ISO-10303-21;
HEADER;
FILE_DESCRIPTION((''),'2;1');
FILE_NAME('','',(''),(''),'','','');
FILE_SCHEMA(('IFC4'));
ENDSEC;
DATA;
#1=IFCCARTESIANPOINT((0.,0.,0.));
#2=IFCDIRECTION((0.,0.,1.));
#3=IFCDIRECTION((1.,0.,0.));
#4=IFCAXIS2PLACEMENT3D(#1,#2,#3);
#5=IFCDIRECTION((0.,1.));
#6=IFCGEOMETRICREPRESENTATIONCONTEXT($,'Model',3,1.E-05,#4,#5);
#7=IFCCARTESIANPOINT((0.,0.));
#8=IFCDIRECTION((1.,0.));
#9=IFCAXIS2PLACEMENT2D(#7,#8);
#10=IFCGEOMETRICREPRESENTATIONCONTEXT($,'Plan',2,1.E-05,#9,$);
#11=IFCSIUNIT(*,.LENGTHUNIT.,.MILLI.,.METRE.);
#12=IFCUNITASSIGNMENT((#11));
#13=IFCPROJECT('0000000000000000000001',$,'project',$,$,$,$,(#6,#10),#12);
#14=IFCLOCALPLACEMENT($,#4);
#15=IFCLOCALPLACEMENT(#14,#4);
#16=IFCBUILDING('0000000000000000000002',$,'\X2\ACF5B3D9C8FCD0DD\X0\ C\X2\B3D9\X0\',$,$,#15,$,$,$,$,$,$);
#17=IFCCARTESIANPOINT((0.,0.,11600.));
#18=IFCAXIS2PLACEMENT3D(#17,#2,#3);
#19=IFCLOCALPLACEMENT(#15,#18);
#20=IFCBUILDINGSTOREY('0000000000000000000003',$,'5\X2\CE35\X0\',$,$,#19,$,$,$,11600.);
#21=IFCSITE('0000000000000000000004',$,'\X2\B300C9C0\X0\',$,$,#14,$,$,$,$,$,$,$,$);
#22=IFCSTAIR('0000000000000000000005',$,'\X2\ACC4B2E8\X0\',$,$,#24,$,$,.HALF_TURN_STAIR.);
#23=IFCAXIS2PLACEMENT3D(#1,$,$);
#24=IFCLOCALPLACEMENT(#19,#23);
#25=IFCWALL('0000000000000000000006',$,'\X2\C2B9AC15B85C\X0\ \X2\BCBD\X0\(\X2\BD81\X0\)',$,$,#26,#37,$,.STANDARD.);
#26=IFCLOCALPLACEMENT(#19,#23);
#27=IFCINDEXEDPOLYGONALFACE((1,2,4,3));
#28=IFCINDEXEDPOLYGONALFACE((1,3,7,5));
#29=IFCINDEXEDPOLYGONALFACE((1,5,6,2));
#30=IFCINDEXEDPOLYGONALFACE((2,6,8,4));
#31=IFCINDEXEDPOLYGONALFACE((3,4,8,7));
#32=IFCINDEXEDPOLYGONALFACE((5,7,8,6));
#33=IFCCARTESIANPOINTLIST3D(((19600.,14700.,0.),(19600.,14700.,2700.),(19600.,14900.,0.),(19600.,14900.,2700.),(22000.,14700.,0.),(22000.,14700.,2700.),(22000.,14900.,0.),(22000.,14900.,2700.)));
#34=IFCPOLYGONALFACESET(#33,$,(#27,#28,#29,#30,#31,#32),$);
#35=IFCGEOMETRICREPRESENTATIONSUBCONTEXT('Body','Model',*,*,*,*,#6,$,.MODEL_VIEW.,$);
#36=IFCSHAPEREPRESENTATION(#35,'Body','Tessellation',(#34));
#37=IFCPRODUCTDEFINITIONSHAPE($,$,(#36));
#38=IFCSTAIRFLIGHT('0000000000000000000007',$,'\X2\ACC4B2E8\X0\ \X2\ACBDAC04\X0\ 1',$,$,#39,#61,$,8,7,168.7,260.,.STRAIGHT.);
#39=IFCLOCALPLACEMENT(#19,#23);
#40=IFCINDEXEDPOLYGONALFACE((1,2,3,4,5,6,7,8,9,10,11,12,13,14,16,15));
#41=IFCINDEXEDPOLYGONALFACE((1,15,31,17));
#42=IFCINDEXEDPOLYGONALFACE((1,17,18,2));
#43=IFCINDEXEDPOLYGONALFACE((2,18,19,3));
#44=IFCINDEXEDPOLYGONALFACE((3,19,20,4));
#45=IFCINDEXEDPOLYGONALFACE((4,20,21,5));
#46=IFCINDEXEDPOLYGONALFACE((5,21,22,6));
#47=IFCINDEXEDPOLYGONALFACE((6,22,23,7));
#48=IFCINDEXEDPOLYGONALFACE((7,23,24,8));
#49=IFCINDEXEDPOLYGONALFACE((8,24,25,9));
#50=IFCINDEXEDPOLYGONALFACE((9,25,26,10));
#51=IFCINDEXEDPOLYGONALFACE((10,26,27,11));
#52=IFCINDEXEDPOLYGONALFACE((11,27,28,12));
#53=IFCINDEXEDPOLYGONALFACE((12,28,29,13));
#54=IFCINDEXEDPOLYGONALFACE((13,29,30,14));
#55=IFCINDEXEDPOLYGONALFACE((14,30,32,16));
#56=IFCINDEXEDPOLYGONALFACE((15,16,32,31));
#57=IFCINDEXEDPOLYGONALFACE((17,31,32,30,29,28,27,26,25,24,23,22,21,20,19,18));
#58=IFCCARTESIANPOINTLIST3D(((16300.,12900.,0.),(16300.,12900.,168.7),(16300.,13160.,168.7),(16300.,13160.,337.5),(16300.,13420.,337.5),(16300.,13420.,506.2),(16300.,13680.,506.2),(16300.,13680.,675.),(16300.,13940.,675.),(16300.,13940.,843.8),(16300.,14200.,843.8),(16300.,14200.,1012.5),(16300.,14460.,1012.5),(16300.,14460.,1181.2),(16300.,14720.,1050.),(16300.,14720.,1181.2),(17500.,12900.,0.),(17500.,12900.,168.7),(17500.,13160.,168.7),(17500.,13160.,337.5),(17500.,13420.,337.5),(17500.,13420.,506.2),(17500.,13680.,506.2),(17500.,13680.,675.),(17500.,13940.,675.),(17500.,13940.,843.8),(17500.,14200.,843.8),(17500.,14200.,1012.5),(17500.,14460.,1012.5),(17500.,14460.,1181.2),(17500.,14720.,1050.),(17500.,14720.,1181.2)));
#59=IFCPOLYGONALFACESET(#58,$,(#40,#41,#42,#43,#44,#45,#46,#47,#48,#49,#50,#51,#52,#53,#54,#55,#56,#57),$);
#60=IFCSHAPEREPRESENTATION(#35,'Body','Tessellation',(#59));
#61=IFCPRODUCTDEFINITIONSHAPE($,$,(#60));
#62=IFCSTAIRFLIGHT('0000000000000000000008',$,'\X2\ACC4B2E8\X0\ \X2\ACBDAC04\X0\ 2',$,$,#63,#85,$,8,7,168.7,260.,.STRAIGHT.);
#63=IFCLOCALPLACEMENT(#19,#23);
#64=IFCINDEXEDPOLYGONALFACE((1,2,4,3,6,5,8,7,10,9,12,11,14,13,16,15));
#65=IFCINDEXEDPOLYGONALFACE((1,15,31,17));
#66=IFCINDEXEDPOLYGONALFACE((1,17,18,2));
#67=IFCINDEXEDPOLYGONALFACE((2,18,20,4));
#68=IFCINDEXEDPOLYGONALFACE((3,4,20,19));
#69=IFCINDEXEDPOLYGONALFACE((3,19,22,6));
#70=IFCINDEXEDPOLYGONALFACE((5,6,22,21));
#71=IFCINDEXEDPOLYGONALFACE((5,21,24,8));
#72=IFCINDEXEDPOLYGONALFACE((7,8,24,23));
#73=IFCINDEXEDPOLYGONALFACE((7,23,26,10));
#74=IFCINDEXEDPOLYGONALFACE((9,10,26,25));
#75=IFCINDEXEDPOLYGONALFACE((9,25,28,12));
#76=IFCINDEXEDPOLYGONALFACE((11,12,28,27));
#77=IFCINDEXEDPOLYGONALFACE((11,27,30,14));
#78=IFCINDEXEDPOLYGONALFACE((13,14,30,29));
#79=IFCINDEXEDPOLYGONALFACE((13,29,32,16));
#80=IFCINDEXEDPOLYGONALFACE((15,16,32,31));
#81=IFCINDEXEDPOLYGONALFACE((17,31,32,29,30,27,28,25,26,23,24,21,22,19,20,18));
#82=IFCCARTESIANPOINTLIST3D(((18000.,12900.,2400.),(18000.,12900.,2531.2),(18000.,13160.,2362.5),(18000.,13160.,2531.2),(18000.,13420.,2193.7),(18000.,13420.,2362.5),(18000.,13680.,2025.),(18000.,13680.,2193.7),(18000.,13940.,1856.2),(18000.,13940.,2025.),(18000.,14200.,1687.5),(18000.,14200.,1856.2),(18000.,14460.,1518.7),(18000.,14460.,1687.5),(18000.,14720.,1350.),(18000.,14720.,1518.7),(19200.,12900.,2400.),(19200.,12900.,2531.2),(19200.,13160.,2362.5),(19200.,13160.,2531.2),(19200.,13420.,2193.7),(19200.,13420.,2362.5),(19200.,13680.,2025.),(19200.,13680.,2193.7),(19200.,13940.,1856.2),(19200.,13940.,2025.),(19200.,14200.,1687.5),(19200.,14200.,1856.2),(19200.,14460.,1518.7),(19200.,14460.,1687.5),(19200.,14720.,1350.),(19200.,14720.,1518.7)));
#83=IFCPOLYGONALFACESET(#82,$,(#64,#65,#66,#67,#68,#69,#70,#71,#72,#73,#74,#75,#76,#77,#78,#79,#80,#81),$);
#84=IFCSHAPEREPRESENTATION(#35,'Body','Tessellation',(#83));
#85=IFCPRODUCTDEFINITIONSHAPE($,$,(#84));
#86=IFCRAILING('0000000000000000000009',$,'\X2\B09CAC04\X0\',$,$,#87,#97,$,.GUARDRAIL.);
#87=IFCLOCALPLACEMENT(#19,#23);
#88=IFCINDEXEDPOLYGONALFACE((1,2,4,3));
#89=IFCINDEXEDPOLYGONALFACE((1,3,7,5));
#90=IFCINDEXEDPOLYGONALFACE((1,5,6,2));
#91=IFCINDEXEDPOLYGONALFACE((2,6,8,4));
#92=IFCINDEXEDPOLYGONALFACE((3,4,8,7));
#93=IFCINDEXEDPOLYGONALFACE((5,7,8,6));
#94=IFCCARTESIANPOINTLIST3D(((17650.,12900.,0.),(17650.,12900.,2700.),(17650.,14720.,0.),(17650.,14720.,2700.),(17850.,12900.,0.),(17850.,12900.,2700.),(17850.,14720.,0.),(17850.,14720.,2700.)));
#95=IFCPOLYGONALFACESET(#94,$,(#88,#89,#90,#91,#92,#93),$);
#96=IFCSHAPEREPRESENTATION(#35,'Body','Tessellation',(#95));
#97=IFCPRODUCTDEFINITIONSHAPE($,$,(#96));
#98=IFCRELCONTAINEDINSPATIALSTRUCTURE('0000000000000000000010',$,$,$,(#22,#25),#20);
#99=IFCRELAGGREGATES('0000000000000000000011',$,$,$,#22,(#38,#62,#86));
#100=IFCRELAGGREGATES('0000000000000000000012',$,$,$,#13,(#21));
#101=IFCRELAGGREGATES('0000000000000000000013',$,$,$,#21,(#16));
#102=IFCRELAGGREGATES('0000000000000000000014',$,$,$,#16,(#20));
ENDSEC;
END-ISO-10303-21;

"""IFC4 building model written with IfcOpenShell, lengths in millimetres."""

from ifc_helpers import new_model, si_unit, direction, frame, origin_with_axes, origin_2d_with_axis, place, context, subcontext, project, spatial, polyline, outline, extrude, element, aggregate, save


model = new_model("IFC4")

# Units and contexts
model_context = context("Model", 3, precision=1e-05, world=origin_with_axes(), true_north=direction((0.0, 1.0)))
plan_context = context("Plan", 2, precision=1e-05, world=origin_2d_with_axis())
body_context = subcontext(model_context, "Body", "Model", "MODEL_VIEW")
ifc_project = project(units=[si_unit("LENGTHUNIT", "METRE", prefix="MILLI")], contexts=[model_context, plan_context])

# Site, building, storey
site_placement = place(None, origin_with_axes())
site = spatial("IfcSite", under=ifc_project, at=site_placement, Name="대지")
building_placement = place(site_placement, origin_with_axes())
building = spatial("IfcBuilding", under=site, at=building_placement, Name="공동주택 C동")
storey_placement = place(building_placement, frame((0.0, 0.0, 11600.0), z_axis=(0.0, 0.0, 1.0), x_axis=(1.0, 0.0, 0.0)))
storey = spatial("IfcBuildingStorey", under=building, at=storey_placement, Name="5층", Elevation=11600.0)

# Stair
stair_placement = place(storey_placement, origin_with_axes())
stair = element("IfcStair", 1, at=stair_placement, inside=storey, Name="계단", PredefinedType="HALF_TURN_STAIR")

# Wall
wall_1_placement = place(storey_placement, origin_with_axes())
element("IfcWall", 2, at=wall_1_placement, inside=storey, Name="승강로 벽(북)", PredefinedType="STANDARD", context=body_context, shape_type="SweptSolid", body=[
    extrude(outline(polyline([(19600.0, 14900.0), (22000.0, 14900.0), (22000.0, 14700.0), (19600.0, 14700.0), (19600.0, 14900.0)])), origin_with_axes(), (0.0, 0.0, 1.0), 2700.0),
])

# Stair flights
stair_flight_1_placement = place(stair_placement, origin_with_axes())
stair_flight_1 = element("IfcStairFlight", 3, at=stair_flight_1_placement, Name="계단 경간 1", NumberOfRisers=8, NumberOfTreads=7, PredefinedType="STRAIGHT", RiserHeight=168.7, TreadLength=260.0, context=body_context, shape_type="SweptSolid", body=[
    extrude(outline(polyline([(0.0, 0.0), (0.0, 168.7), (260.0, 168.7), (260.0, 337.5), (520.0, 337.5), (520.0, 506.2), (780.0, 506.2), (780.0, 675.0), (1040.0, 675.0), (1040.0, 843.7), (1300.0, 843.7), (1300.0, 1012.5), (1560.0, 1012.5), (1560.0, 1181.2), (1820.0, 1181.2), (1820.0, 1350.0), (1820.0, 1050.0), (0.0, 0.0)])), frame((16300.0, 12900.0, 0.0), z_axis=(1.0, 0.0, 0.0), x_axis=(0.0, 1.0, 0.0)), (0.0, 0.0, 1.0), 1200.0),
])
stair_flight_2_placement = place(stair_placement, origin_with_axes())
stair_flight_2 = element("IfcStairFlight", 4, at=stair_flight_2_placement, Name="계단 경간 2", NumberOfRisers=8, NumberOfTreads=7, PredefinedType="STRAIGHT", RiserHeight=168.7, TreadLength=260.0, context=body_context, shape_type="SweptSolid", body=[
    extrude(outline(polyline([(0.0, 0.0), (0.0, 168.7), (260.0, 168.7), (260.0, 337.5), (520.0, 337.5), (520.0, 506.2), (780.0, 506.2), (780.0, 675.0), (1040.0, 675.0), (1040.0, 843.7), (1300.0, 843.7), (1300.0, 1012.5), (1560.0, 1012.5), (1560.0, 1181.2), (1820.0, 1181.2), (1820.0, 1350.0), (1820.0, 1050.0), (0.0, 0.0)])), frame((19200.0, 14720.0, 1350.0), z_axis=(-1.0, 0.0, 0.0), x_axis=(0.0, -1.0, 0.0)), (0.0, 0.0, 1.0), 1200.0),
])

# Railing
railing_placement = place(stair_placement, origin_with_axes())
railing = element("IfcRailing", 5, at=railing_placement, Name="난간", PredefinedType="GUARDRAIL", context=body_context, shape_type="SweptSolid", body=[
    extrude(outline(polyline([(17650.0, 12900.0), (17850.0, 12900.0), (17850.0, 14720.0), (17650.0, 14720.0), (17650.0, 12900.0)])), origin_with_axes(), (0.0, 0.0, 1.0), 2700.0),
])
aggregate(stair, [stair_flight_1, stair_flight_2, railing])

save(model, "model.ifc")
